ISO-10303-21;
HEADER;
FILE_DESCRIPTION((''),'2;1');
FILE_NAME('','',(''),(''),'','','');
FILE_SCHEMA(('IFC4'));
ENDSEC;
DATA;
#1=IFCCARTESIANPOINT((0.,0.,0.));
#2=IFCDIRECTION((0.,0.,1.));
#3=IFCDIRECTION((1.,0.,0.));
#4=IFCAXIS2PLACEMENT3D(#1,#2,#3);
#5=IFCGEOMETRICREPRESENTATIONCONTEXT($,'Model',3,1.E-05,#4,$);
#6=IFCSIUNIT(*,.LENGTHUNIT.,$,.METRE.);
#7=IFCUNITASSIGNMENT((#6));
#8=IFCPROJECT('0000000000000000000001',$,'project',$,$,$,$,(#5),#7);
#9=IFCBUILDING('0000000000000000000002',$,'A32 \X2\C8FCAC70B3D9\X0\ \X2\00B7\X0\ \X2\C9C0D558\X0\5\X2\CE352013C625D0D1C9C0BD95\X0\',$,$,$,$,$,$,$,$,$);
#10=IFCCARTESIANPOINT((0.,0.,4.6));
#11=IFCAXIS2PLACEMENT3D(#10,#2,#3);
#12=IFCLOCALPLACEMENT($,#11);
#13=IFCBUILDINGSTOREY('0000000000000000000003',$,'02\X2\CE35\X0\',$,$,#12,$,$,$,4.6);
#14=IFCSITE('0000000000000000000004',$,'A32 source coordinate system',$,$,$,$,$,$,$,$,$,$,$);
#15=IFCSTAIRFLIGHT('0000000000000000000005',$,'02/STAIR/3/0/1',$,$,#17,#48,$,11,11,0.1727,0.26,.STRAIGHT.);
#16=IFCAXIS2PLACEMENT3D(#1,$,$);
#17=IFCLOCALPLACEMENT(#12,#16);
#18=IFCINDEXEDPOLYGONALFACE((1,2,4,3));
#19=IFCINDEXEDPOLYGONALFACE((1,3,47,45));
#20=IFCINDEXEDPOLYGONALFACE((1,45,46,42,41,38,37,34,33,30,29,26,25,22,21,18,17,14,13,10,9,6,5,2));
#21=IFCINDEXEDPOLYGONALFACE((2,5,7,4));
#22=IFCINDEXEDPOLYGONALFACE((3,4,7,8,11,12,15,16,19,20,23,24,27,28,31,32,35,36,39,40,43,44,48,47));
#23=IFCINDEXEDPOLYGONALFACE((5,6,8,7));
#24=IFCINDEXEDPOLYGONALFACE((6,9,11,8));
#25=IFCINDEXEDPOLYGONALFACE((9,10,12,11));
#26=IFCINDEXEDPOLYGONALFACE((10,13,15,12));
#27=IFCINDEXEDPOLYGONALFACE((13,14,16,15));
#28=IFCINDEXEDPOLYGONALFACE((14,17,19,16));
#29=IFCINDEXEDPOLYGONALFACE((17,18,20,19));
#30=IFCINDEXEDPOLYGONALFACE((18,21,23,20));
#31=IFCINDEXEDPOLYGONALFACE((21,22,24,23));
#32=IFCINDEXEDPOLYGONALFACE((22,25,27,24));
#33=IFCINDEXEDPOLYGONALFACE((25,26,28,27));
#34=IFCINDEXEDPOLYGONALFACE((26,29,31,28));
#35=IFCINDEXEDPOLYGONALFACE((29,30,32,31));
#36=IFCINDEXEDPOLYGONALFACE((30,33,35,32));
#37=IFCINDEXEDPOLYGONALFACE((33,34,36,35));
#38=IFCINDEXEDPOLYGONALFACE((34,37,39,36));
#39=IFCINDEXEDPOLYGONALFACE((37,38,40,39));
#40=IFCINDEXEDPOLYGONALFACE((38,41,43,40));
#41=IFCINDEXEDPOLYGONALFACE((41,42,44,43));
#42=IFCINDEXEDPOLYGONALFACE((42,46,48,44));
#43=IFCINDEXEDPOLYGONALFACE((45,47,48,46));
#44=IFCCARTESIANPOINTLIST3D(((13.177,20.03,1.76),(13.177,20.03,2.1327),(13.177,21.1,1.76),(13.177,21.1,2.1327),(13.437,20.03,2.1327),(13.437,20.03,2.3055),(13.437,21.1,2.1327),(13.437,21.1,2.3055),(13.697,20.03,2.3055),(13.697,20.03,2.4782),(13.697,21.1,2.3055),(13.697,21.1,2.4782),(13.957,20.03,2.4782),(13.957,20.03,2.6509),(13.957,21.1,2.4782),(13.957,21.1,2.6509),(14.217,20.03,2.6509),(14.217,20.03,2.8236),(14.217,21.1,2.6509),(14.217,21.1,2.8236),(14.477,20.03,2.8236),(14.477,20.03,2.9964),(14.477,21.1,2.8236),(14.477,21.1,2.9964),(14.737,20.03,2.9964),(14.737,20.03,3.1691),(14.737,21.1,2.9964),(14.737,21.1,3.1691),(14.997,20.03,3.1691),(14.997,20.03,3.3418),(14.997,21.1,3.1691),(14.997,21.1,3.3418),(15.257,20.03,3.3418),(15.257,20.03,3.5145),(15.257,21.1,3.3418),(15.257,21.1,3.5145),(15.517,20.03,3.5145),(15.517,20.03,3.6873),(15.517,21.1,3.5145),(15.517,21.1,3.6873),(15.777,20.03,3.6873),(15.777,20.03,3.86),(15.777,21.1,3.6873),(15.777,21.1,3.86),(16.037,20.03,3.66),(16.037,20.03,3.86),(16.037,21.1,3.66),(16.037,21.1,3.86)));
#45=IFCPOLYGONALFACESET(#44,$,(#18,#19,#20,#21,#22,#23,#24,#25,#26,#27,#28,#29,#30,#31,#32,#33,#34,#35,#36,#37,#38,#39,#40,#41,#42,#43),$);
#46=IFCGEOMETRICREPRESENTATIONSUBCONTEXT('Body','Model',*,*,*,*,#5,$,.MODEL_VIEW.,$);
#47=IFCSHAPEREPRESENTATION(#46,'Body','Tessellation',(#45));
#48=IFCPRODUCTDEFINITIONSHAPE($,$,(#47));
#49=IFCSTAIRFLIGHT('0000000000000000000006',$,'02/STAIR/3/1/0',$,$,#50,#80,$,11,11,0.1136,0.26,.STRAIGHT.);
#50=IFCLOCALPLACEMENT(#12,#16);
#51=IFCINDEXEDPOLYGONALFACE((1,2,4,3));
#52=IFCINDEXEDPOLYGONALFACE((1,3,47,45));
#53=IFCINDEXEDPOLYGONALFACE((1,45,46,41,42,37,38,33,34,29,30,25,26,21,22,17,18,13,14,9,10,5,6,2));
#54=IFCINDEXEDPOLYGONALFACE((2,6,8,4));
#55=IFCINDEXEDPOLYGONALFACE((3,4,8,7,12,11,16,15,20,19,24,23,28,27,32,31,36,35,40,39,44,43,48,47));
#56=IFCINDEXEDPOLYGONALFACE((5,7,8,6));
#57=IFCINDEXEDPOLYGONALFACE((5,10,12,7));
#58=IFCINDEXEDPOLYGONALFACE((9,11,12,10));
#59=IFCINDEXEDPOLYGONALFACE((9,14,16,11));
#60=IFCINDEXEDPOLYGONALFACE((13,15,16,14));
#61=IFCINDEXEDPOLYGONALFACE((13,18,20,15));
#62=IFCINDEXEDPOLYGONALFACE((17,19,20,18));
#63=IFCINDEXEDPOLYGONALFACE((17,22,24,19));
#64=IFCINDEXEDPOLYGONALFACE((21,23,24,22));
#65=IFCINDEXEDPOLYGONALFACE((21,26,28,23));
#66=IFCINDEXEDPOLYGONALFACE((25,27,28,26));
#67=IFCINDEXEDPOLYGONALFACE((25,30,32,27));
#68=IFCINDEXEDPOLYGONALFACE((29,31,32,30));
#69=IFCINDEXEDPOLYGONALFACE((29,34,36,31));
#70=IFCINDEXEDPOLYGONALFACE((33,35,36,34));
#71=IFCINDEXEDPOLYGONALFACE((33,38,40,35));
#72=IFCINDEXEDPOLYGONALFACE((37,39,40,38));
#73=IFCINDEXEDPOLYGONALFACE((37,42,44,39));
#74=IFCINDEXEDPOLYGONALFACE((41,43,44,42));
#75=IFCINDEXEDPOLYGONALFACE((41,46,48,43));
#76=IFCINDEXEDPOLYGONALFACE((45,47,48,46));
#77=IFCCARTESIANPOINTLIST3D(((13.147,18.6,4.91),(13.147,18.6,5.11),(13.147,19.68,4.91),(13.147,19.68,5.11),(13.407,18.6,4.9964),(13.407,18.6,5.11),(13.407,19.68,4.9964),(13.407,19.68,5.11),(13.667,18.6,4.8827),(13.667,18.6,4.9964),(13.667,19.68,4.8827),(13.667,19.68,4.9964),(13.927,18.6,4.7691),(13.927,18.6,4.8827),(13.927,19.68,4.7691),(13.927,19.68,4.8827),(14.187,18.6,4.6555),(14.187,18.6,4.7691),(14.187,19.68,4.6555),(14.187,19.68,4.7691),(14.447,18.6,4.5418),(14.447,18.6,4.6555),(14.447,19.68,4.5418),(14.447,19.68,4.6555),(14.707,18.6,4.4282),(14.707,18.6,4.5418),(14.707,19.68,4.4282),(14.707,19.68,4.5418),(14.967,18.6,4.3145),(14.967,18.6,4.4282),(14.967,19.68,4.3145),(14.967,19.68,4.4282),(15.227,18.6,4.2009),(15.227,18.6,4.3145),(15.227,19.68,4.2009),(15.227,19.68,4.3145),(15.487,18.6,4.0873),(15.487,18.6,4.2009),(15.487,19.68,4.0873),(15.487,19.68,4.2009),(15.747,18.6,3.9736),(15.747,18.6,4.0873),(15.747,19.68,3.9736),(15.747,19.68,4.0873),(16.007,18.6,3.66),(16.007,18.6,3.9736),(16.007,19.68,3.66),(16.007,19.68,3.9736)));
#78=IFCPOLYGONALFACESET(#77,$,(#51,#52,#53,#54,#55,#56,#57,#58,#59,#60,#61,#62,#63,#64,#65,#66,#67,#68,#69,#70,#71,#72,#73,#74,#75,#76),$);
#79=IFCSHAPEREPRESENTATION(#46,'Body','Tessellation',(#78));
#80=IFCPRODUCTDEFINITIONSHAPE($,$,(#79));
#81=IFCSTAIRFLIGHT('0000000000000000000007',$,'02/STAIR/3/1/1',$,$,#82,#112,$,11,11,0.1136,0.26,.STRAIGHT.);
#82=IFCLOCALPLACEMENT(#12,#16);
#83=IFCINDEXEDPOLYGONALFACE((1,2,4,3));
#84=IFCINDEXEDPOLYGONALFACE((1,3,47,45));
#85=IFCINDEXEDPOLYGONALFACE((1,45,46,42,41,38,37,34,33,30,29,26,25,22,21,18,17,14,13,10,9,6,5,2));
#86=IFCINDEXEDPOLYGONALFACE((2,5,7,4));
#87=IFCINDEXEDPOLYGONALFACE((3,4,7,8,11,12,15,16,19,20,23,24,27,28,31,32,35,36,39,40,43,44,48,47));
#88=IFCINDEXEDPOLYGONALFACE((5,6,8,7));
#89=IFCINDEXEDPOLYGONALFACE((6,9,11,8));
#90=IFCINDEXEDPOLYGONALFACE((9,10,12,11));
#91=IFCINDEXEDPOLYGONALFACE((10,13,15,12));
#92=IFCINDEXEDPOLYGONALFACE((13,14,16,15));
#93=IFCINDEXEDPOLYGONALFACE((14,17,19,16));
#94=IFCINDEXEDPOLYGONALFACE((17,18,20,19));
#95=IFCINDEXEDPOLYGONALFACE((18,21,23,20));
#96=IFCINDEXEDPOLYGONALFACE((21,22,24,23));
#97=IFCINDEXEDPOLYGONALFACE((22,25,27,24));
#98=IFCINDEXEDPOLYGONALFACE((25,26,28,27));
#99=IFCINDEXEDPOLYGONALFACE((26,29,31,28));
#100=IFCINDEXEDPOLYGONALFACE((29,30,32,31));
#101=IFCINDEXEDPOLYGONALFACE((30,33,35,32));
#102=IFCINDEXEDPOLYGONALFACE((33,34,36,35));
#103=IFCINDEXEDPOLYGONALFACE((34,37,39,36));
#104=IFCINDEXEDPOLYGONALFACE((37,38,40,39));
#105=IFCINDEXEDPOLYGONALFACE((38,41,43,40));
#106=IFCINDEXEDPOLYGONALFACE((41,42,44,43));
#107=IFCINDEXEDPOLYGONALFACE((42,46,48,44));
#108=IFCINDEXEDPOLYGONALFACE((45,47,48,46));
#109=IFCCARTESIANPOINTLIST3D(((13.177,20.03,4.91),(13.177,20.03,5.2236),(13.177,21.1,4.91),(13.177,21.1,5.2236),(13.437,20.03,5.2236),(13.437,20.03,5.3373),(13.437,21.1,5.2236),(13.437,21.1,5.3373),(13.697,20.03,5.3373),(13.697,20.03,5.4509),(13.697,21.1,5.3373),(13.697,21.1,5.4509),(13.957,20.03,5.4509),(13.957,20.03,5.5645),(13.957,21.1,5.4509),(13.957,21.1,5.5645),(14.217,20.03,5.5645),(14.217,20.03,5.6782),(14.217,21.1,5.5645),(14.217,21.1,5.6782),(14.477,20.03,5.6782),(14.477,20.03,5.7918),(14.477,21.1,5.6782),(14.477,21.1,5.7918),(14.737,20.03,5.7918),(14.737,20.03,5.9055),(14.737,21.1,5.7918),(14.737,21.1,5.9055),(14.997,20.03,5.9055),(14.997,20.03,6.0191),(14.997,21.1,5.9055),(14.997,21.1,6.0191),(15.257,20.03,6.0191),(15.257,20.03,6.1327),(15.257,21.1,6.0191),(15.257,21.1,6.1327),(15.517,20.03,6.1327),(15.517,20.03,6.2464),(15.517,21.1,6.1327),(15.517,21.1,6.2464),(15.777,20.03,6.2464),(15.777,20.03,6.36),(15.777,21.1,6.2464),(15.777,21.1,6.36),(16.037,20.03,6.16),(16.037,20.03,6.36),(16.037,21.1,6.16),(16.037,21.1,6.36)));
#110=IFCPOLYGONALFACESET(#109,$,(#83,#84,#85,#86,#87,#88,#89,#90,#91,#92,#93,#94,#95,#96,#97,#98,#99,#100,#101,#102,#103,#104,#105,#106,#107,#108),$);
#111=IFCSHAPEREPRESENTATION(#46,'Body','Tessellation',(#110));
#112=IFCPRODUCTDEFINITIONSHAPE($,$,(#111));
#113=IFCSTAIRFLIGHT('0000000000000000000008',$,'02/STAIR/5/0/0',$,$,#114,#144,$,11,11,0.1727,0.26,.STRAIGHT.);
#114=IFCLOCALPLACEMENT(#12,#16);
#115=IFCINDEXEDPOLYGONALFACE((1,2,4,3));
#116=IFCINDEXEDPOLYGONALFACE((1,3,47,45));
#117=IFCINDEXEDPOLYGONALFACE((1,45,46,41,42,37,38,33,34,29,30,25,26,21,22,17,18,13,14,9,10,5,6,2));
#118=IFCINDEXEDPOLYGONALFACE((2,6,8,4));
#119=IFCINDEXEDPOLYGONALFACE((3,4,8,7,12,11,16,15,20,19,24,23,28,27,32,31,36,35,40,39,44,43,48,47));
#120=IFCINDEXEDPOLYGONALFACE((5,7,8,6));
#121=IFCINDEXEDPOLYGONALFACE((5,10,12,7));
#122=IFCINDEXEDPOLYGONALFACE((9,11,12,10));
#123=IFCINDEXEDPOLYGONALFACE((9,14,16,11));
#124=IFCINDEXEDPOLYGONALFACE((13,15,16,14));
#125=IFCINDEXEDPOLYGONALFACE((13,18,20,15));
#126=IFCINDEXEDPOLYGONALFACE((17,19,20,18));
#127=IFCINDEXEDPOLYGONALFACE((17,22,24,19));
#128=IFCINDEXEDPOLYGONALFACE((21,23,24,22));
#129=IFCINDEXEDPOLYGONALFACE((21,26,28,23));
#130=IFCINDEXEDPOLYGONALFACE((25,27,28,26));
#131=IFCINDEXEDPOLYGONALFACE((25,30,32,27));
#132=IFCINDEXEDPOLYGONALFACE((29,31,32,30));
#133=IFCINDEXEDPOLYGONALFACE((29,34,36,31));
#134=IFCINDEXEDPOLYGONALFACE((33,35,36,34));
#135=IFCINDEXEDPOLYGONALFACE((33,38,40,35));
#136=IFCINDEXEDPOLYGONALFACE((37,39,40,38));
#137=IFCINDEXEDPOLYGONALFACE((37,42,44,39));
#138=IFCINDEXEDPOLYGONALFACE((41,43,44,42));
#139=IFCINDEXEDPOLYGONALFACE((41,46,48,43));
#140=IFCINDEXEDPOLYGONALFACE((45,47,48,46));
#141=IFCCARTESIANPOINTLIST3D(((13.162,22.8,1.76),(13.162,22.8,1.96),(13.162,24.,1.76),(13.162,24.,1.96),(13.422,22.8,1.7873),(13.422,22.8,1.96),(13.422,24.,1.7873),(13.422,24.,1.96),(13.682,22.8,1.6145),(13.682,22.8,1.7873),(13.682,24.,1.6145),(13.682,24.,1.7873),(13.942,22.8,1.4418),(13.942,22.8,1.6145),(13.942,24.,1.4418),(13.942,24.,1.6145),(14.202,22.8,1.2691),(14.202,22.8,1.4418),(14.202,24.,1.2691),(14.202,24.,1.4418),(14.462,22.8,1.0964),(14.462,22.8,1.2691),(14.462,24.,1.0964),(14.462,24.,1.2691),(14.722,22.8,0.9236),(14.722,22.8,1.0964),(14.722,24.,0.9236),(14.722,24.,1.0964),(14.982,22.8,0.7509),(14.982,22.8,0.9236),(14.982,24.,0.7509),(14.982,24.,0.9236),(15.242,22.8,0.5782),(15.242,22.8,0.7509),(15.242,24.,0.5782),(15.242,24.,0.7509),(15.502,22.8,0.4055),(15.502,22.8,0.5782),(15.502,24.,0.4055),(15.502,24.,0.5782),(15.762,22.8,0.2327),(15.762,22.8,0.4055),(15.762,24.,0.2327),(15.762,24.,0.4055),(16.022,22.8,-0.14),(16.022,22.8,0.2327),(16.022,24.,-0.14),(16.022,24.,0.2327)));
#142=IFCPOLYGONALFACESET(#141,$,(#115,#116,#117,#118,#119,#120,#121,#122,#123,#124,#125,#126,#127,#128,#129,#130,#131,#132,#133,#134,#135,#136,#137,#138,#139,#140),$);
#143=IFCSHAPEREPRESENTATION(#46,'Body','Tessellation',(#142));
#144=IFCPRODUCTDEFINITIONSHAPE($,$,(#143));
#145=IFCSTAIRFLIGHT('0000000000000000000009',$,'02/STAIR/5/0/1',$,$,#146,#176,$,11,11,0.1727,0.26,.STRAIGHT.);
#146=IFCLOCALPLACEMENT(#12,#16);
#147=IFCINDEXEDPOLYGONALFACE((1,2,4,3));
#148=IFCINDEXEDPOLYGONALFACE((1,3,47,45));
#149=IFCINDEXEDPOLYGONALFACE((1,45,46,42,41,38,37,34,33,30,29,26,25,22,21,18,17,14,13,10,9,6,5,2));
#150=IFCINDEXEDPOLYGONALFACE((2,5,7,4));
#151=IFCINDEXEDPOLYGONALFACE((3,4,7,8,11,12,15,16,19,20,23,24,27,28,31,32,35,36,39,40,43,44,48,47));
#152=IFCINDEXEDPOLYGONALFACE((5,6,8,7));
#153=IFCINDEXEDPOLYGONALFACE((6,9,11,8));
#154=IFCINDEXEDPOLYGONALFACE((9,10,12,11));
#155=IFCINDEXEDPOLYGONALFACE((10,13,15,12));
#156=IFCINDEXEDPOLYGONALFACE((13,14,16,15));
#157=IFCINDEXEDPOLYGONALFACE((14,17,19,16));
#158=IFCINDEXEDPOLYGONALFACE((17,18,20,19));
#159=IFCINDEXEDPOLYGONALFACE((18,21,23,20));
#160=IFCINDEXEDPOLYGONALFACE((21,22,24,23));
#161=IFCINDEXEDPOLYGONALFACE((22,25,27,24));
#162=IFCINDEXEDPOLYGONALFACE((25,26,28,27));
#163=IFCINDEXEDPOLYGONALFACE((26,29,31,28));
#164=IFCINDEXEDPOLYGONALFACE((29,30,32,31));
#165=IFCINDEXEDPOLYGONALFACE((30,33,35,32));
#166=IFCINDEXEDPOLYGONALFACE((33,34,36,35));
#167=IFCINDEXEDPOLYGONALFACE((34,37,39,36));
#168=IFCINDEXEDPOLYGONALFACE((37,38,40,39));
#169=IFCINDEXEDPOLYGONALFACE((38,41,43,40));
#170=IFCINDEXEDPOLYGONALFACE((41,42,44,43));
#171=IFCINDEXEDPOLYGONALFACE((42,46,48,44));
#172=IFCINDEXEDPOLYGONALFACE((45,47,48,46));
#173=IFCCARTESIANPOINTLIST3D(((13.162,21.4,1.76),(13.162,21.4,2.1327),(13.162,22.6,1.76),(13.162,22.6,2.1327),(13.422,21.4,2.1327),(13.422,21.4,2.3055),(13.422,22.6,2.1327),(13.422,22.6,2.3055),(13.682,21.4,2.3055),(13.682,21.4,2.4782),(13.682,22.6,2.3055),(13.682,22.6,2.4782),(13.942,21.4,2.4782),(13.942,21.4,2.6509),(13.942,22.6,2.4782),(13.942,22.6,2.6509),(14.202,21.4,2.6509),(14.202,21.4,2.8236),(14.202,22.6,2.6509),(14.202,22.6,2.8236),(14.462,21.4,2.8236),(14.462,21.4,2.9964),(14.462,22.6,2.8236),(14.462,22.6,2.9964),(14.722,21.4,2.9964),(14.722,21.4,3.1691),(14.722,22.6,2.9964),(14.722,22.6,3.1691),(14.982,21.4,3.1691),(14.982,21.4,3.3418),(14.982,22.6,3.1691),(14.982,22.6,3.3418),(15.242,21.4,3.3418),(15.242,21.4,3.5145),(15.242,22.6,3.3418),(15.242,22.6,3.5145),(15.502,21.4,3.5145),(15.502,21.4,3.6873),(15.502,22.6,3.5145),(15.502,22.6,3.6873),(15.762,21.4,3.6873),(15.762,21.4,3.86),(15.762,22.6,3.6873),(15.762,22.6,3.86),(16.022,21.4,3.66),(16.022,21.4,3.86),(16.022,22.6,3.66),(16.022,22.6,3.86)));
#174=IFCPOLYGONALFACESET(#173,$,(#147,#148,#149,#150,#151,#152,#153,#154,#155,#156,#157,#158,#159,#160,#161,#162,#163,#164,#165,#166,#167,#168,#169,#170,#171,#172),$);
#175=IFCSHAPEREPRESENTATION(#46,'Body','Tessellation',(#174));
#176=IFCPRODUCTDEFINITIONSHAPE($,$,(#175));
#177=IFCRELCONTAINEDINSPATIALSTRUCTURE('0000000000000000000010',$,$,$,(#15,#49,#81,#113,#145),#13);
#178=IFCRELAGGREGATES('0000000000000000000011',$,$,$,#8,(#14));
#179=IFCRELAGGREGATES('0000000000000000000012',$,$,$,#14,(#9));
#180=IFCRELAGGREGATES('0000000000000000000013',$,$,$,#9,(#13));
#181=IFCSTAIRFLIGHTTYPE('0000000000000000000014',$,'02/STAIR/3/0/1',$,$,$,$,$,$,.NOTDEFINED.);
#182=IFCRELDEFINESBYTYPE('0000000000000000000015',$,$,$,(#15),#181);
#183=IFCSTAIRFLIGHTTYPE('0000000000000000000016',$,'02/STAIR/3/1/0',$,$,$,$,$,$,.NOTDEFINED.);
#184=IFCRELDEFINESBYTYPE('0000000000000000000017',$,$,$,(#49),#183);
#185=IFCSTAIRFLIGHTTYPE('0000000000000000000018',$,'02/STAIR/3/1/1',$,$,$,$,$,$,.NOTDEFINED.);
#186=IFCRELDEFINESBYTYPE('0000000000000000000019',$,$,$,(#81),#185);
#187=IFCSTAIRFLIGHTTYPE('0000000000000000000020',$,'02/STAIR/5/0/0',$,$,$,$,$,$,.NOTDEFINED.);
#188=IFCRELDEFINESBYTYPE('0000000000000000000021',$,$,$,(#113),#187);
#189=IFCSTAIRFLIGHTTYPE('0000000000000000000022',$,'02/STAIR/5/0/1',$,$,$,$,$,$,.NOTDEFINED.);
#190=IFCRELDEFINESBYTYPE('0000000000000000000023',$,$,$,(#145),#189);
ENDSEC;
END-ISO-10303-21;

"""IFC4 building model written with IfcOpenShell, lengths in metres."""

from ifc_helpers import new_model, si_unit, frame, origin, origin_with_axes, place, context, subcontext, project, spatial, polyline, outline, extrude, source, transform, mapped, type_object, type_shapes, element, save


model = new_model("IFC4")

# Units and contexts
model_context = context("Model", 3, precision=1e-05, world=origin_with_axes())
body_context = subcontext(model_context, "Body", "Model", "MODEL_VIEW")
ifc_project = project(units=[si_unit("LENGTHUNIT", "METRE")], contexts=[model_context])

# Site, building, storey
storey_placement = place(None, frame((0.0, 0.0, 4.6), z_axis=(0.0, 0.0, 1.0), x_axis=(1.0, 0.0, 0.0)))
site = spatial("IfcSite", under=ifc_project, Name="A32 source coordinate system")
building = spatial("IfcBuilding", under=site, Name="A32 주거동 · 지하5층–옥탑지붕")
storey = spatial("IfcBuildingStorey", under=building, at=storey_placement, Name="02층", Elevation=4.6)

# Stair flights
stair_flight_type_1 = type_object("IfcStairFlightType", Name="02/STAIR/3/0/1", PredefinedType="NOTDEFINED")
shared_shape_1 = source(origin(), body_context, "Body", "SweptSolid", [
    extrude(outline(polyline([(0.0, 1.76), (2.86, 3.66), (2.86, 3.86), (2.6, 3.86), (2.6, 3.6873), (2.34, 3.6873), (2.34, 3.5145), (2.08, 3.5145), (2.08, 3.3418), (1.82, 3.3418), (1.82, 3.1691), (1.56, 3.1691), (1.56, 2.9964), (1.3, 2.9964), (1.3, 2.8236), (1.04, 2.8236), (1.04, 2.6509), (0.78, 2.6509), (0.78, 2.4782), (0.52, 2.4782), (0.52, 2.3055), (0.26, 2.3055), (0.26, 2.1327), (0.0, 2.1327), (0.0, 1.76)])), frame((13.177, 21.1, 0.0), z_axis=(0.0, -1.0, 0.0), x_axis=(1.0, 0.0, 0.0)), (0.0, 0.0, 1.0), 1.07),
])
type_shapes(stair_flight_type_1, [shared_shape_1])
stair_flight_1_placement = place(storey_placement, origin_with_axes())
element("IfcStairFlight", 1, at=stair_flight_1_placement, inside=storey, type_object=stair_flight_type_1, Name="02/STAIR/3/0/1", NumberOfRisers=11, NumberOfTreads=11, PredefinedType="STRAIGHT", RiserHeight=0.1727, TreadLength=0.26, context=body_context, shape_type="MappedRepresentation", body=[
    mapped(shared_shape_1, transform((0.0, 0.0, 0.0), scale=1.0)),
])
stair_flight_type_2 = type_object("IfcStairFlightType", Name="02/STAIR/3/1/0", PredefinedType="NOTDEFINED")
shared_shape_2 = source(origin(), body_context, "Body", "SweptSolid", [
    extrude(outline(polyline([(0.0, 3.66), (2.86, 4.91), (2.86, 5.11), (2.6, 5.11), (2.6, 4.9964), (2.34, 4.9964), (2.34, 4.8827), (2.08, 4.8827), (2.08, 4.7691), (1.82, 4.7691), (1.82, 4.6555), (1.56, 4.6555), (1.56, 4.5418), (1.3, 4.5418), (1.3, 4.4282), (1.04, 4.4282), (1.04, 4.3145), (0.78, 4.3145), (0.78, 4.2009), (0.52, 4.2009), (0.52, 4.0873), (0.26, 4.0873), (0.26, 3.9736), (0.0, 3.9736), (0.0, 3.66)])), frame((16.007, 18.6, 0.0), z_axis=(0.0, 1.0, 0.0), x_axis=(-1.0, 0.0, 0.0)), (0.0, 0.0, 1.0), 1.08),
])
type_shapes(stair_flight_type_2, [shared_shape_2])
stair_flight_2_placement = place(storey_placement, origin_with_axes())
element("IfcStairFlight", 2, at=stair_flight_2_placement, inside=storey, type_object=stair_flight_type_2, Name="02/STAIR/3/1/0", NumberOfRisers=11, NumberOfTreads=11, PredefinedType="STRAIGHT", RiserHeight=0.1136, TreadLength=0.26, context=body_context, shape_type="MappedRepresentation", body=[
    mapped(shared_shape_2, transform((0.0, 0.0, 0.0), scale=1.0)),
])
stair_flight_type_3 = type_object("IfcStairFlightType", Name="02/STAIR/3/1/1", PredefinedType="NOTDEFINED")
shared_shape_3 = source(origin(), body_context, "Body", "SweptSolid", [
    extrude(outline(polyline([(0.0, 4.91), (2.86, 6.16), (2.86, 6.36), (2.6, 6.36), (2.6, 6.2464), (2.34, 6.2464), (2.34, 6.1327), (2.08, 6.1327), (2.08, 6.0191), (1.82, 6.0191), (1.82, 5.9055), (1.56, 5.9055), (1.56, 5.7918), (1.3, 5.7918), (1.3, 5.6782), (1.04, 5.6782), (1.04, 5.5645), (0.78, 5.5645), (0.78, 5.4509), (0.52, 5.4509), (0.52, 5.3373), (0.26, 5.3373), (0.26, 5.2236), (0.0, 5.2236), (0.0, 4.91)])), frame((13.177, 21.1, 0.0), z_axis=(0.0, -1.0, 0.0), x_axis=(1.0, 0.0, 0.0)), (0.0, 0.0, 1.0), 1.07),
])
type_shapes(stair_flight_type_3, [shared_shape_3])
stair_flight_3_placement = place(storey_placement, origin_with_axes())
element("IfcStairFlight", 3, at=stair_flight_3_placement, inside=storey, type_object=stair_flight_type_3, Name="02/STAIR/3/1/1", NumberOfRisers=11, NumberOfTreads=11, PredefinedType="STRAIGHT", RiserHeight=0.1136, TreadLength=0.26, context=body_context, shape_type="MappedRepresentation", body=[
    mapped(shared_shape_3, transform((0.0, 0.0, 0.0), scale=1.0)),
])
stair_flight_type_4 = type_object("IfcStairFlightType", Name="02/STAIR/5/0/0", PredefinedType="NOTDEFINED")
shared_shape_4 = source(origin(), body_context, "Body", "SweptSolid", [
    extrude(outline(polyline([(0.0, -0.14), (2.86, 1.76), (2.86, 1.96), (2.6, 1.96), (2.6, 1.7873), (2.34, 1.7873), (2.34, 1.6145), (2.08, 1.6145), (2.08, 1.4418), (1.82, 1.4418), (1.82, 1.2691), (1.56, 1.2691), (1.56, 1.0964), (1.3, 1.0964), (1.3, 0.9236), (1.04, 0.9236), (1.04, 0.7509), (0.78, 0.7509), (0.78, 0.5782), (0.52, 0.5782), (0.52, 0.4055), (0.26, 0.4055), (0.26, 0.2327), (0.0, 0.2327), (0.0, -0.14)])), frame((16.022, 22.8, 0.0), z_axis=(0.0, 1.0, 0.0), x_axis=(-1.0, 0.0, 0.0)), (0.0, 0.0, 1.0), 1.2),
])
type_shapes(stair_flight_type_4, [shared_shape_4])
stair_flight_4_placement = place(storey_placement, origin_with_axes())
element("IfcStairFlight", 4, at=stair_flight_4_placement, inside=storey, type_object=stair_flight_type_4, Name="02/STAIR/5/0/0", NumberOfRisers=11, NumberOfTreads=11, PredefinedType="STRAIGHT", RiserHeight=0.1727, TreadLength=0.26, context=body_context, shape_type="MappedRepresentation", body=[
    mapped(shared_shape_4, transform((0.0, 0.0, 0.0), scale=1.0)),
])
stair_flight_type_5 = type_object("IfcStairFlightType", Name="02/STAIR/5/0/1", PredefinedType="NOTDEFINED")
shared_shape_5 = source(origin(), body_context, "Body", "SweptSolid", [
    extrude(outline(polyline([(0.0, 1.76), (2.86, 3.66), (2.86, 3.86), (2.6, 3.86), (2.6, 3.6873), (2.34, 3.6873), (2.34, 3.5145), (2.08, 3.5145), (2.08, 3.3418), (1.82, 3.3418), (1.82, 3.1691), (1.56, 3.1691), (1.56, 2.9964), (1.3, 2.9964), (1.3, 2.8236), (1.04, 2.8236), (1.04, 2.6509), (0.78, 2.6509), (0.78, 2.4782), (0.52, 2.4782), (0.52, 2.3055), (0.26, 2.3055), (0.26, 2.1327), (0.0, 2.1327), (0.0, 1.76)])), frame((13.162, 22.6, 0.0), z_axis=(0.0, -1.0, 0.0), x_axis=(1.0, 0.0, 0.0)), (0.0, 0.0, 1.0), 1.2),
])
type_shapes(stair_flight_type_5, [shared_shape_5])
stair_flight_5_placement = place(storey_placement, origin_with_axes())
element("IfcStairFlight", 5, at=stair_flight_5_placement, inside=storey, type_object=stair_flight_type_5, Name="02/STAIR/5/0/1", NumberOfRisers=11, NumberOfTreads=11, PredefinedType="STRAIGHT", RiserHeight=0.1727, TreadLength=0.26, context=body_context, shape_type="MappedRepresentation", body=[
    mapped(shared_shape_5, transform((0.0, 0.0, 0.0), scale=1.0)),
])

save(model, "model.ifc")
